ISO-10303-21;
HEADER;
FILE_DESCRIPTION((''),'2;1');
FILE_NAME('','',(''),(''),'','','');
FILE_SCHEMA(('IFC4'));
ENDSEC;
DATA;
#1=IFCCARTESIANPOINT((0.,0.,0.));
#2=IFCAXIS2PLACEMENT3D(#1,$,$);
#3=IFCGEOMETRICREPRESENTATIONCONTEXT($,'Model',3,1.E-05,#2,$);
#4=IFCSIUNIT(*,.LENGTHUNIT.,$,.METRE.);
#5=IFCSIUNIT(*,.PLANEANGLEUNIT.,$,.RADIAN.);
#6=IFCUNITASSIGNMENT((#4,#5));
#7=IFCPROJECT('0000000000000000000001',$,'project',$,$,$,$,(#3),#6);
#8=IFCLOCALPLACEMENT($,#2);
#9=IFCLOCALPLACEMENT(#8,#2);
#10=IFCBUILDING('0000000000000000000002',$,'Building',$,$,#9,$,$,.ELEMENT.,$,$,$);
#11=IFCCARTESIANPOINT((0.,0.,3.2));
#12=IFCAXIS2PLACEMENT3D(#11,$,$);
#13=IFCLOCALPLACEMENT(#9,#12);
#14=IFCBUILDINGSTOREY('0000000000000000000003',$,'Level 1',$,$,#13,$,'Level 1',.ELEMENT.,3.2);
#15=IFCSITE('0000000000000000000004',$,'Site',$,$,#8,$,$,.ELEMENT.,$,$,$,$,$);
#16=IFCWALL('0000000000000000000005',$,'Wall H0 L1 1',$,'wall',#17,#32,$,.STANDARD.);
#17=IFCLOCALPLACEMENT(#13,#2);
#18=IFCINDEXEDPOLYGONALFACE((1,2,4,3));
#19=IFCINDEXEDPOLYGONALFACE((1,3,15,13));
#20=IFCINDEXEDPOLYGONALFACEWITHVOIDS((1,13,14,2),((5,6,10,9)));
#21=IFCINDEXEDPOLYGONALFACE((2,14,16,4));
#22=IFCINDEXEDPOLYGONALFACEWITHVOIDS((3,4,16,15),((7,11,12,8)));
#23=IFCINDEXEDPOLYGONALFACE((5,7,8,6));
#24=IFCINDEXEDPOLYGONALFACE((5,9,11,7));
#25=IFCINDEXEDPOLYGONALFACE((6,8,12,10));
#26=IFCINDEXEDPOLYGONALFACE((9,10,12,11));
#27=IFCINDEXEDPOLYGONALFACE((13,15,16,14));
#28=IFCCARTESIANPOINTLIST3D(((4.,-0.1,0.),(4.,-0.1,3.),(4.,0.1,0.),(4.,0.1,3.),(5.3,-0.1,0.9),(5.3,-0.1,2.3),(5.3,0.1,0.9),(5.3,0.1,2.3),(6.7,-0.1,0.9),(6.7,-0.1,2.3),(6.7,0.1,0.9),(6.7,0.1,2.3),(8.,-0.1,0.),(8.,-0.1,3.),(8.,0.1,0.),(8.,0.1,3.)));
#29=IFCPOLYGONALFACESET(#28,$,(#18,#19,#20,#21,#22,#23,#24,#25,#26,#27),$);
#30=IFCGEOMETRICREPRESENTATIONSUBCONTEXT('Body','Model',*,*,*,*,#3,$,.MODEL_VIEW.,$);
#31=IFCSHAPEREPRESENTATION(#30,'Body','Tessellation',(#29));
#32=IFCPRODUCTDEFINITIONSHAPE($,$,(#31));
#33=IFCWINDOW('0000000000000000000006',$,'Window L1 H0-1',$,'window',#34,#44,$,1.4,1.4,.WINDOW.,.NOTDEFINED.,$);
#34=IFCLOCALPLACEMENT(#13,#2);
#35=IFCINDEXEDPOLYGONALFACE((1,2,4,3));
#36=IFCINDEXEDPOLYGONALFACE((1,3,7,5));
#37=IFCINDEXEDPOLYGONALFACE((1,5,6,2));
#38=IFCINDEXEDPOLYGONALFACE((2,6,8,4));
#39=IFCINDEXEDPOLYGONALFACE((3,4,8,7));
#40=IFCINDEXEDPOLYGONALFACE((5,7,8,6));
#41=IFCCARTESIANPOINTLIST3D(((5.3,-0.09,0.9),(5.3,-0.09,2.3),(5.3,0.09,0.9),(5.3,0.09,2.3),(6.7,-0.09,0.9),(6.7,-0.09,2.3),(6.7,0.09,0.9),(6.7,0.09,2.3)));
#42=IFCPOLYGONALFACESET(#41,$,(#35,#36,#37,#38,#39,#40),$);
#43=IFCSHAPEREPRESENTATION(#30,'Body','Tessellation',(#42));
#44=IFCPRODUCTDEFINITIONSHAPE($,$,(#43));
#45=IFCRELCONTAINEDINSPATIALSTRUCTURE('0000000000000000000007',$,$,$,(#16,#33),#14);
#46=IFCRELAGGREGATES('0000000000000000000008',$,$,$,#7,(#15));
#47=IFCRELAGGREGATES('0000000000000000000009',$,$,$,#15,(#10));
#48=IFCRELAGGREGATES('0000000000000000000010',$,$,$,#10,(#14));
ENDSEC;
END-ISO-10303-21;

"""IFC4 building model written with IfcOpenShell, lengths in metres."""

from ifc_helpers import new_model, si_unit, frame, frame_2d, origin, origin_2d, place, context, subcontext, project, spatial, rectangle, extrude, element, fill, save


model = new_model("IFC4")

# Units and contexts
model_context = context("Model", 3, precision=1e-05, world=origin())
body_context = subcontext(model_context, "Body", "Model", "MODEL_VIEW")
ifc_project = project(units=[si_unit("LENGTHUNIT", "METRE"), si_unit("PLANEANGLEUNIT", "RADIAN")], contexts=[model_context])

# Site, building, storey
site_placement = place(None, origin())
site = spatial("IfcSite", under=ifc_project, at=site_placement, Name="Site", CompositionType="ELEMENT")
building_placement = place(site_placement, origin())
building = spatial("IfcBuilding", under=site, at=building_placement, Name="Building", CompositionType="ELEMENT")
storey_placement = place(building_placement, frame((0.0, 0.0, 3.2)))
storey = spatial("IfcBuildingStorey", under=building, at=storey_placement, Name="Level 1", LongName="Level 1", CompositionType="ELEMENT", Elevation=3.2)

# Wall, opening, window
wall_1_placement = place(storey_placement, frame((4.0, 0.0, 0.0), z_axis=(0.0, 0.0, 1.0), x_axis=(1.0, 0.0, 0.0)))
wall_1 = element("IfcWall", 1, at=wall_1_placement, inside=storey, Name="Wall H0 L1 1", ObjectType="wall", PredefinedType="STANDARD", context=body_context, shape_type="SweptSolid", body=[
    extrude(rectangle(XDim=4.0, YDim=0.2, at=frame_2d((2.0, 0.0))), origin(), (0.0, 0.0, 1.0), 3.0),
])
opening_placement = place(storey_placement, frame((6.0, 0.0, 0.9), z_axis=(0.0, 0.0, 1.0), x_axis=(1.0, 0.0, 0.0)))
opening = element("IfcOpeningElement", 2, at=opening_placement, cuts=wall_1, ObjectType="Opening", PredefinedType="OPENING", context=body_context, shape_type="SweptSolid", body=[
    extrude(rectangle(XDim=1.4, YDim=0.22, at=origin_2d()), origin(), (0.0, 0.0, 1.0), 1.4),
])
window_placement = place(storey_placement, frame((6.0, 0.0, 0.9), z_axis=(0.0, 0.0, 1.0), x_axis=(1.0, 0.0, 0.0)))
window = element("IfcWindow", 3, at=window_placement, inside=storey, Name="Window L1 H0-1", ObjectType="window", OverallHeight=1.4, OverallWidth=1.4, PartitioningType="NOTDEFINED", PredefinedType="WINDOW", context=body_context, shape_type="SweptSolid", body=[
    extrude(rectangle(XDim=1.4, YDim=0.18, at=origin_2d()), origin(), (0.0, 0.0, 1.0), 1.4),
])
fill(opening, window)

save(model, "model.ifc")
